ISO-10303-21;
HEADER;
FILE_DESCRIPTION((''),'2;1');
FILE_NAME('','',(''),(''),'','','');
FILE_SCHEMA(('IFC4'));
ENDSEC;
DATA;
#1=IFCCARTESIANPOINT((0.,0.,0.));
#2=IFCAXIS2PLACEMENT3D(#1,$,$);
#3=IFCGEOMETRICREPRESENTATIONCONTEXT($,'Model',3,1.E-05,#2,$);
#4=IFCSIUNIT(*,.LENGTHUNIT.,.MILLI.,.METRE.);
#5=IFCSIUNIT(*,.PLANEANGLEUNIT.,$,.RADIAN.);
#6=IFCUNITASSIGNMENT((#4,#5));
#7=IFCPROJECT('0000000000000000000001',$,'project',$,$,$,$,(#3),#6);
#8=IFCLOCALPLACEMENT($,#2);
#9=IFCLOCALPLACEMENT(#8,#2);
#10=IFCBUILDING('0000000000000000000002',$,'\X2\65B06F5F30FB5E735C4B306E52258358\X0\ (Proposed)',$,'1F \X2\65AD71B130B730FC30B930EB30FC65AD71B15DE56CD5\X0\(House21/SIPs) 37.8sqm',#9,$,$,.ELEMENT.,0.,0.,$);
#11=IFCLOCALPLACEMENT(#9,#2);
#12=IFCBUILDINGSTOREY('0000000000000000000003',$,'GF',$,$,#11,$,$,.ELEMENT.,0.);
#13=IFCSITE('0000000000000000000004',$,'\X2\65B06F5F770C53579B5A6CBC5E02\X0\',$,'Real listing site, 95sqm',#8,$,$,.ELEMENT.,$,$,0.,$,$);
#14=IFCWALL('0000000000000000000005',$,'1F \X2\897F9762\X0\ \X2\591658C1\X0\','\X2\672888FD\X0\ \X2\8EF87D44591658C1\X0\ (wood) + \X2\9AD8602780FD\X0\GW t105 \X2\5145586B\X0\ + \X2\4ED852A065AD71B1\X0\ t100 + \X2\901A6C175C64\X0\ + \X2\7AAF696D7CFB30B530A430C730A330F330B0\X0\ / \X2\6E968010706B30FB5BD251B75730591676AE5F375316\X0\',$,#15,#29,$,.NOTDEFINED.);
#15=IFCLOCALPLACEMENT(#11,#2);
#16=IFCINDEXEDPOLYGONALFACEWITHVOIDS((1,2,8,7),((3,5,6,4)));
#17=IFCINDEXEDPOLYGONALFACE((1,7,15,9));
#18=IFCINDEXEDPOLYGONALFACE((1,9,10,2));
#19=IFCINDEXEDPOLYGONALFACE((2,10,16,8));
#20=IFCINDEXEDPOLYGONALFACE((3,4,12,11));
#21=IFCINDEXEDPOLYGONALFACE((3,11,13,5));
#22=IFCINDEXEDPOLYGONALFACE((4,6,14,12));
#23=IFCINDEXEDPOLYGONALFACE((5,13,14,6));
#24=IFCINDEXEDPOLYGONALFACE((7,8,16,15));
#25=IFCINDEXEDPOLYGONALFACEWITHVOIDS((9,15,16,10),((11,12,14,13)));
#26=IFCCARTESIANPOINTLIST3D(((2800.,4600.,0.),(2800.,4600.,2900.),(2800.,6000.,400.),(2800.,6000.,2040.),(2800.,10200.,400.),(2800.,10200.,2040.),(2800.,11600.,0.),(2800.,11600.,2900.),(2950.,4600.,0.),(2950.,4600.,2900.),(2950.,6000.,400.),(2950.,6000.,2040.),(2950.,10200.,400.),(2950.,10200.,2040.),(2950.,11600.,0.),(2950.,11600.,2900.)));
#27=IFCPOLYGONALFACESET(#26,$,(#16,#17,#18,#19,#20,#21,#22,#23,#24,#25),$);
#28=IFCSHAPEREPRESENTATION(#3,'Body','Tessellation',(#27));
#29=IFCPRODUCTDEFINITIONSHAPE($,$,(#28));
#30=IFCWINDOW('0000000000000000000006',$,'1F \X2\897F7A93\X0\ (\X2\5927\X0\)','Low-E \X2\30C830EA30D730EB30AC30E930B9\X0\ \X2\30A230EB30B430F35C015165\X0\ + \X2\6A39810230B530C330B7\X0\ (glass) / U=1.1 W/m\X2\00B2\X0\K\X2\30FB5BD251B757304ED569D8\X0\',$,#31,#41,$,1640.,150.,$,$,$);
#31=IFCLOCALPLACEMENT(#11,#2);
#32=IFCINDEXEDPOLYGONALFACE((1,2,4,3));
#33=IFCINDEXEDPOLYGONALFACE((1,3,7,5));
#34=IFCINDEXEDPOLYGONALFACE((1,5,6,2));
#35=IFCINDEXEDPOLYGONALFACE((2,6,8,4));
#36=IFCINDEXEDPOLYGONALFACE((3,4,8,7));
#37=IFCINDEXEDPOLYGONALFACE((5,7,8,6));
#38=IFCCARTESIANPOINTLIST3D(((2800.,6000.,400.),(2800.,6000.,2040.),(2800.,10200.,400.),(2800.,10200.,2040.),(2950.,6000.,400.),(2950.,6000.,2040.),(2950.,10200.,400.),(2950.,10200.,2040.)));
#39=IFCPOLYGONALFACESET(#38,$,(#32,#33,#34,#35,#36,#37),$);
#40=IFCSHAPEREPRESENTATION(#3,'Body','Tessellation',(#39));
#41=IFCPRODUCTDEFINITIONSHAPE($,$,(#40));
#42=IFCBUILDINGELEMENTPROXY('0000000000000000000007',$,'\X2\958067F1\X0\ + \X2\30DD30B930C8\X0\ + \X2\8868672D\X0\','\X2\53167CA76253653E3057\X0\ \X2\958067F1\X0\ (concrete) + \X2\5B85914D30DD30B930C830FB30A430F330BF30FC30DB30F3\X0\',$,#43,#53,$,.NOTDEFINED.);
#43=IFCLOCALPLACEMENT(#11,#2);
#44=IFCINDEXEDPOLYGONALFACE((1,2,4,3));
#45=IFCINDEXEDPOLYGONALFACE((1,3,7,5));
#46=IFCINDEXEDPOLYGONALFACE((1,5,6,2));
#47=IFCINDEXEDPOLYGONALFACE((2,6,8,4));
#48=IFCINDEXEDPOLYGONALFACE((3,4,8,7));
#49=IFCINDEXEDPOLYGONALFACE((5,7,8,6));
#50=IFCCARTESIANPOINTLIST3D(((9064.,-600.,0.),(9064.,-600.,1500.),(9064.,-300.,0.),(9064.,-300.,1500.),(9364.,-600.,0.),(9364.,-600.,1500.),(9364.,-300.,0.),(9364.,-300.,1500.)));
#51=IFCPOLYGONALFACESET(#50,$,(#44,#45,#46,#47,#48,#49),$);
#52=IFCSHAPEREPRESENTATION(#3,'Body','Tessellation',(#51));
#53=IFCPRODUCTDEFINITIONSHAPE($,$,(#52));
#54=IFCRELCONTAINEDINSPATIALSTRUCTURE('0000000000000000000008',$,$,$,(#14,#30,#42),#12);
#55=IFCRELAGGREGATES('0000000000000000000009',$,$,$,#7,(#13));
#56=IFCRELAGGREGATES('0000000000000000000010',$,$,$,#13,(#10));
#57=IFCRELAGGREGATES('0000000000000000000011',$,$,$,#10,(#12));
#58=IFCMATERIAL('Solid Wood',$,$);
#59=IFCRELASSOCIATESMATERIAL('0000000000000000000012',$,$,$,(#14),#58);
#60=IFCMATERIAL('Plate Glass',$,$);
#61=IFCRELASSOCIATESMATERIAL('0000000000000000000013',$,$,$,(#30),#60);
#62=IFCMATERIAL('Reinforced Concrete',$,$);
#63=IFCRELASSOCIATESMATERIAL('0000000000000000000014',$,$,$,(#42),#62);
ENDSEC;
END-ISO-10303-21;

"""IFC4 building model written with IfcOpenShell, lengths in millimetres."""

from ifc_helpers import new_model, si_unit, frame, frame_2d, origin, place, context, project, spatial, rectangle, extrude, material, element, fill, save


model = new_model("IFC4")

# Units and contexts
model_context = context("Model", 3, precision=1e-05, world=origin())
ifc_project = project(units=[si_unit("LENGTHUNIT", "METRE", prefix="MILLI"), si_unit("PLANEANGLEUNIT", "RADIAN")], contexts=[model_context])

# Site, building, storey
site_placement = place(None, origin())
site = spatial("IfcSite", under=ifc_project, at=site_placement, Name="新潟県南魚沼市", ObjectType="Real listing site, 95sqm", CompositionType="ELEMENT", RefElevation=0.0)
building_placement = place(site_placement, origin())
building = spatial("IfcBuilding", under=site, at=building_placement, Name="新潟・平屋の別荘 (Proposed)", ObjectType="1F 断熱シースルー断熱工法(House21/SIPs) 37.8sqm", CompositionType="ELEMENT", ElevationOfRefHeight=0.0, ElevationOfTerrain=0.0)
storey_placement = place(building_placement, origin())
storey = spatial("IfcBuildingStorey", under=building, at=storey_placement, Name="GF", CompositionType="ELEMENT", Elevation=0.0)

# Shared definitions
ifc_material_1 = material(Name="Solid Wood")

# Shared definitions
ifc_material_2 = material(Name="Reinforced Concrete")

# Shared definitions
ifc_material_3 = material(Name="Plate Glass")

# Wall, opening, window
wall_1_placement = place(storey_placement, frame((1400.0, 2300.0, 0.0)))
wall_1 = element("IfcWall", 1, at=wall_1_placement, inside=storey, material=ifc_material_1, Name="1F 西面 外壁", Description="木製 軸組外壁 (wood) + 高性能GW t105 充填 + 付加断熱 t100 + 通気層 + 窯業系サイディング / 準耐火・寒冷地外皮強化", PredefinedType="NOTDEFINED", context=model_context, shape_type="SweptSolid", body=[
    extrude(rectangle(XDim=150.0, YDim=7000.0, at=frame_2d((75.0, 3500.0))), frame((1400.0, 2300.0, 0.0)), (0.0, 0.0, 1.0), 2900.0),
])
opening_1_placement = place(storey_placement, frame((1400.0, 3000.0, 200.0)))
opening_1 = element("IfcOpeningElement", 2, at=opening_1_placement, cuts=wall_1, PredefinedType="NOTDEFINED", context=model_context, shape_type="SweptSolid", body=[
    extrude(rectangle(XDim=150.0, YDim=4200.0, at=frame_2d((75.0, 2100.0))), frame((1400.0, 3000.0, 200.0)), (0.0, 0.0, 1.0), 1640.0),
])
window_1_placement = place(storey_placement, frame((1400.0, 3000.0, 200.0)))
window_1 = element("IfcWindow", 3, at=window_1_placement, inside=storey, material=ifc_material_3, Name="1F 西窓 (大)", Description="Low-E トリプルガラス アルゴン封入 + 樹脂サッシ (glass) / U=1.1 W/m²K・寒冷地仕様", OverallHeight=1640.0, OverallWidth=150.0, context=model_context, shape_type="SweptSolid", body=[
    extrude(rectangle(XDim=150.0, YDim=4200.0, at=frame_2d((75.0, 2100.0))), frame((1400.0, 3000.0, 200.0)), (0.0, 0.0, 1.0), 1640.0),
])
fill(opening_1, window_1)

# Building element proxy
proxy_placement = place(storey_placement, frame((4532.0, -300.0, 0.0)))
element("IfcBuildingElementProxy", 4, at=proxy_placement, inside=storey, material=ifc_material_2, Name="門柱 + ポスト + 表札", Description="化粧打放し 門柱 (concrete) + 宅配ポスト・インターホン", PredefinedType="NOTDEFINED", context=model_context, shape_type="SweptSolid", body=[
    extrude(rectangle(XDim=300.0, YDim=300.0, at=frame_2d((150.0, 150.0))), frame((4532.0, -300.0, 0.0)), (0.0, 0.0, 1.0), 1500.0),
])

save(model, "model.ifc")
